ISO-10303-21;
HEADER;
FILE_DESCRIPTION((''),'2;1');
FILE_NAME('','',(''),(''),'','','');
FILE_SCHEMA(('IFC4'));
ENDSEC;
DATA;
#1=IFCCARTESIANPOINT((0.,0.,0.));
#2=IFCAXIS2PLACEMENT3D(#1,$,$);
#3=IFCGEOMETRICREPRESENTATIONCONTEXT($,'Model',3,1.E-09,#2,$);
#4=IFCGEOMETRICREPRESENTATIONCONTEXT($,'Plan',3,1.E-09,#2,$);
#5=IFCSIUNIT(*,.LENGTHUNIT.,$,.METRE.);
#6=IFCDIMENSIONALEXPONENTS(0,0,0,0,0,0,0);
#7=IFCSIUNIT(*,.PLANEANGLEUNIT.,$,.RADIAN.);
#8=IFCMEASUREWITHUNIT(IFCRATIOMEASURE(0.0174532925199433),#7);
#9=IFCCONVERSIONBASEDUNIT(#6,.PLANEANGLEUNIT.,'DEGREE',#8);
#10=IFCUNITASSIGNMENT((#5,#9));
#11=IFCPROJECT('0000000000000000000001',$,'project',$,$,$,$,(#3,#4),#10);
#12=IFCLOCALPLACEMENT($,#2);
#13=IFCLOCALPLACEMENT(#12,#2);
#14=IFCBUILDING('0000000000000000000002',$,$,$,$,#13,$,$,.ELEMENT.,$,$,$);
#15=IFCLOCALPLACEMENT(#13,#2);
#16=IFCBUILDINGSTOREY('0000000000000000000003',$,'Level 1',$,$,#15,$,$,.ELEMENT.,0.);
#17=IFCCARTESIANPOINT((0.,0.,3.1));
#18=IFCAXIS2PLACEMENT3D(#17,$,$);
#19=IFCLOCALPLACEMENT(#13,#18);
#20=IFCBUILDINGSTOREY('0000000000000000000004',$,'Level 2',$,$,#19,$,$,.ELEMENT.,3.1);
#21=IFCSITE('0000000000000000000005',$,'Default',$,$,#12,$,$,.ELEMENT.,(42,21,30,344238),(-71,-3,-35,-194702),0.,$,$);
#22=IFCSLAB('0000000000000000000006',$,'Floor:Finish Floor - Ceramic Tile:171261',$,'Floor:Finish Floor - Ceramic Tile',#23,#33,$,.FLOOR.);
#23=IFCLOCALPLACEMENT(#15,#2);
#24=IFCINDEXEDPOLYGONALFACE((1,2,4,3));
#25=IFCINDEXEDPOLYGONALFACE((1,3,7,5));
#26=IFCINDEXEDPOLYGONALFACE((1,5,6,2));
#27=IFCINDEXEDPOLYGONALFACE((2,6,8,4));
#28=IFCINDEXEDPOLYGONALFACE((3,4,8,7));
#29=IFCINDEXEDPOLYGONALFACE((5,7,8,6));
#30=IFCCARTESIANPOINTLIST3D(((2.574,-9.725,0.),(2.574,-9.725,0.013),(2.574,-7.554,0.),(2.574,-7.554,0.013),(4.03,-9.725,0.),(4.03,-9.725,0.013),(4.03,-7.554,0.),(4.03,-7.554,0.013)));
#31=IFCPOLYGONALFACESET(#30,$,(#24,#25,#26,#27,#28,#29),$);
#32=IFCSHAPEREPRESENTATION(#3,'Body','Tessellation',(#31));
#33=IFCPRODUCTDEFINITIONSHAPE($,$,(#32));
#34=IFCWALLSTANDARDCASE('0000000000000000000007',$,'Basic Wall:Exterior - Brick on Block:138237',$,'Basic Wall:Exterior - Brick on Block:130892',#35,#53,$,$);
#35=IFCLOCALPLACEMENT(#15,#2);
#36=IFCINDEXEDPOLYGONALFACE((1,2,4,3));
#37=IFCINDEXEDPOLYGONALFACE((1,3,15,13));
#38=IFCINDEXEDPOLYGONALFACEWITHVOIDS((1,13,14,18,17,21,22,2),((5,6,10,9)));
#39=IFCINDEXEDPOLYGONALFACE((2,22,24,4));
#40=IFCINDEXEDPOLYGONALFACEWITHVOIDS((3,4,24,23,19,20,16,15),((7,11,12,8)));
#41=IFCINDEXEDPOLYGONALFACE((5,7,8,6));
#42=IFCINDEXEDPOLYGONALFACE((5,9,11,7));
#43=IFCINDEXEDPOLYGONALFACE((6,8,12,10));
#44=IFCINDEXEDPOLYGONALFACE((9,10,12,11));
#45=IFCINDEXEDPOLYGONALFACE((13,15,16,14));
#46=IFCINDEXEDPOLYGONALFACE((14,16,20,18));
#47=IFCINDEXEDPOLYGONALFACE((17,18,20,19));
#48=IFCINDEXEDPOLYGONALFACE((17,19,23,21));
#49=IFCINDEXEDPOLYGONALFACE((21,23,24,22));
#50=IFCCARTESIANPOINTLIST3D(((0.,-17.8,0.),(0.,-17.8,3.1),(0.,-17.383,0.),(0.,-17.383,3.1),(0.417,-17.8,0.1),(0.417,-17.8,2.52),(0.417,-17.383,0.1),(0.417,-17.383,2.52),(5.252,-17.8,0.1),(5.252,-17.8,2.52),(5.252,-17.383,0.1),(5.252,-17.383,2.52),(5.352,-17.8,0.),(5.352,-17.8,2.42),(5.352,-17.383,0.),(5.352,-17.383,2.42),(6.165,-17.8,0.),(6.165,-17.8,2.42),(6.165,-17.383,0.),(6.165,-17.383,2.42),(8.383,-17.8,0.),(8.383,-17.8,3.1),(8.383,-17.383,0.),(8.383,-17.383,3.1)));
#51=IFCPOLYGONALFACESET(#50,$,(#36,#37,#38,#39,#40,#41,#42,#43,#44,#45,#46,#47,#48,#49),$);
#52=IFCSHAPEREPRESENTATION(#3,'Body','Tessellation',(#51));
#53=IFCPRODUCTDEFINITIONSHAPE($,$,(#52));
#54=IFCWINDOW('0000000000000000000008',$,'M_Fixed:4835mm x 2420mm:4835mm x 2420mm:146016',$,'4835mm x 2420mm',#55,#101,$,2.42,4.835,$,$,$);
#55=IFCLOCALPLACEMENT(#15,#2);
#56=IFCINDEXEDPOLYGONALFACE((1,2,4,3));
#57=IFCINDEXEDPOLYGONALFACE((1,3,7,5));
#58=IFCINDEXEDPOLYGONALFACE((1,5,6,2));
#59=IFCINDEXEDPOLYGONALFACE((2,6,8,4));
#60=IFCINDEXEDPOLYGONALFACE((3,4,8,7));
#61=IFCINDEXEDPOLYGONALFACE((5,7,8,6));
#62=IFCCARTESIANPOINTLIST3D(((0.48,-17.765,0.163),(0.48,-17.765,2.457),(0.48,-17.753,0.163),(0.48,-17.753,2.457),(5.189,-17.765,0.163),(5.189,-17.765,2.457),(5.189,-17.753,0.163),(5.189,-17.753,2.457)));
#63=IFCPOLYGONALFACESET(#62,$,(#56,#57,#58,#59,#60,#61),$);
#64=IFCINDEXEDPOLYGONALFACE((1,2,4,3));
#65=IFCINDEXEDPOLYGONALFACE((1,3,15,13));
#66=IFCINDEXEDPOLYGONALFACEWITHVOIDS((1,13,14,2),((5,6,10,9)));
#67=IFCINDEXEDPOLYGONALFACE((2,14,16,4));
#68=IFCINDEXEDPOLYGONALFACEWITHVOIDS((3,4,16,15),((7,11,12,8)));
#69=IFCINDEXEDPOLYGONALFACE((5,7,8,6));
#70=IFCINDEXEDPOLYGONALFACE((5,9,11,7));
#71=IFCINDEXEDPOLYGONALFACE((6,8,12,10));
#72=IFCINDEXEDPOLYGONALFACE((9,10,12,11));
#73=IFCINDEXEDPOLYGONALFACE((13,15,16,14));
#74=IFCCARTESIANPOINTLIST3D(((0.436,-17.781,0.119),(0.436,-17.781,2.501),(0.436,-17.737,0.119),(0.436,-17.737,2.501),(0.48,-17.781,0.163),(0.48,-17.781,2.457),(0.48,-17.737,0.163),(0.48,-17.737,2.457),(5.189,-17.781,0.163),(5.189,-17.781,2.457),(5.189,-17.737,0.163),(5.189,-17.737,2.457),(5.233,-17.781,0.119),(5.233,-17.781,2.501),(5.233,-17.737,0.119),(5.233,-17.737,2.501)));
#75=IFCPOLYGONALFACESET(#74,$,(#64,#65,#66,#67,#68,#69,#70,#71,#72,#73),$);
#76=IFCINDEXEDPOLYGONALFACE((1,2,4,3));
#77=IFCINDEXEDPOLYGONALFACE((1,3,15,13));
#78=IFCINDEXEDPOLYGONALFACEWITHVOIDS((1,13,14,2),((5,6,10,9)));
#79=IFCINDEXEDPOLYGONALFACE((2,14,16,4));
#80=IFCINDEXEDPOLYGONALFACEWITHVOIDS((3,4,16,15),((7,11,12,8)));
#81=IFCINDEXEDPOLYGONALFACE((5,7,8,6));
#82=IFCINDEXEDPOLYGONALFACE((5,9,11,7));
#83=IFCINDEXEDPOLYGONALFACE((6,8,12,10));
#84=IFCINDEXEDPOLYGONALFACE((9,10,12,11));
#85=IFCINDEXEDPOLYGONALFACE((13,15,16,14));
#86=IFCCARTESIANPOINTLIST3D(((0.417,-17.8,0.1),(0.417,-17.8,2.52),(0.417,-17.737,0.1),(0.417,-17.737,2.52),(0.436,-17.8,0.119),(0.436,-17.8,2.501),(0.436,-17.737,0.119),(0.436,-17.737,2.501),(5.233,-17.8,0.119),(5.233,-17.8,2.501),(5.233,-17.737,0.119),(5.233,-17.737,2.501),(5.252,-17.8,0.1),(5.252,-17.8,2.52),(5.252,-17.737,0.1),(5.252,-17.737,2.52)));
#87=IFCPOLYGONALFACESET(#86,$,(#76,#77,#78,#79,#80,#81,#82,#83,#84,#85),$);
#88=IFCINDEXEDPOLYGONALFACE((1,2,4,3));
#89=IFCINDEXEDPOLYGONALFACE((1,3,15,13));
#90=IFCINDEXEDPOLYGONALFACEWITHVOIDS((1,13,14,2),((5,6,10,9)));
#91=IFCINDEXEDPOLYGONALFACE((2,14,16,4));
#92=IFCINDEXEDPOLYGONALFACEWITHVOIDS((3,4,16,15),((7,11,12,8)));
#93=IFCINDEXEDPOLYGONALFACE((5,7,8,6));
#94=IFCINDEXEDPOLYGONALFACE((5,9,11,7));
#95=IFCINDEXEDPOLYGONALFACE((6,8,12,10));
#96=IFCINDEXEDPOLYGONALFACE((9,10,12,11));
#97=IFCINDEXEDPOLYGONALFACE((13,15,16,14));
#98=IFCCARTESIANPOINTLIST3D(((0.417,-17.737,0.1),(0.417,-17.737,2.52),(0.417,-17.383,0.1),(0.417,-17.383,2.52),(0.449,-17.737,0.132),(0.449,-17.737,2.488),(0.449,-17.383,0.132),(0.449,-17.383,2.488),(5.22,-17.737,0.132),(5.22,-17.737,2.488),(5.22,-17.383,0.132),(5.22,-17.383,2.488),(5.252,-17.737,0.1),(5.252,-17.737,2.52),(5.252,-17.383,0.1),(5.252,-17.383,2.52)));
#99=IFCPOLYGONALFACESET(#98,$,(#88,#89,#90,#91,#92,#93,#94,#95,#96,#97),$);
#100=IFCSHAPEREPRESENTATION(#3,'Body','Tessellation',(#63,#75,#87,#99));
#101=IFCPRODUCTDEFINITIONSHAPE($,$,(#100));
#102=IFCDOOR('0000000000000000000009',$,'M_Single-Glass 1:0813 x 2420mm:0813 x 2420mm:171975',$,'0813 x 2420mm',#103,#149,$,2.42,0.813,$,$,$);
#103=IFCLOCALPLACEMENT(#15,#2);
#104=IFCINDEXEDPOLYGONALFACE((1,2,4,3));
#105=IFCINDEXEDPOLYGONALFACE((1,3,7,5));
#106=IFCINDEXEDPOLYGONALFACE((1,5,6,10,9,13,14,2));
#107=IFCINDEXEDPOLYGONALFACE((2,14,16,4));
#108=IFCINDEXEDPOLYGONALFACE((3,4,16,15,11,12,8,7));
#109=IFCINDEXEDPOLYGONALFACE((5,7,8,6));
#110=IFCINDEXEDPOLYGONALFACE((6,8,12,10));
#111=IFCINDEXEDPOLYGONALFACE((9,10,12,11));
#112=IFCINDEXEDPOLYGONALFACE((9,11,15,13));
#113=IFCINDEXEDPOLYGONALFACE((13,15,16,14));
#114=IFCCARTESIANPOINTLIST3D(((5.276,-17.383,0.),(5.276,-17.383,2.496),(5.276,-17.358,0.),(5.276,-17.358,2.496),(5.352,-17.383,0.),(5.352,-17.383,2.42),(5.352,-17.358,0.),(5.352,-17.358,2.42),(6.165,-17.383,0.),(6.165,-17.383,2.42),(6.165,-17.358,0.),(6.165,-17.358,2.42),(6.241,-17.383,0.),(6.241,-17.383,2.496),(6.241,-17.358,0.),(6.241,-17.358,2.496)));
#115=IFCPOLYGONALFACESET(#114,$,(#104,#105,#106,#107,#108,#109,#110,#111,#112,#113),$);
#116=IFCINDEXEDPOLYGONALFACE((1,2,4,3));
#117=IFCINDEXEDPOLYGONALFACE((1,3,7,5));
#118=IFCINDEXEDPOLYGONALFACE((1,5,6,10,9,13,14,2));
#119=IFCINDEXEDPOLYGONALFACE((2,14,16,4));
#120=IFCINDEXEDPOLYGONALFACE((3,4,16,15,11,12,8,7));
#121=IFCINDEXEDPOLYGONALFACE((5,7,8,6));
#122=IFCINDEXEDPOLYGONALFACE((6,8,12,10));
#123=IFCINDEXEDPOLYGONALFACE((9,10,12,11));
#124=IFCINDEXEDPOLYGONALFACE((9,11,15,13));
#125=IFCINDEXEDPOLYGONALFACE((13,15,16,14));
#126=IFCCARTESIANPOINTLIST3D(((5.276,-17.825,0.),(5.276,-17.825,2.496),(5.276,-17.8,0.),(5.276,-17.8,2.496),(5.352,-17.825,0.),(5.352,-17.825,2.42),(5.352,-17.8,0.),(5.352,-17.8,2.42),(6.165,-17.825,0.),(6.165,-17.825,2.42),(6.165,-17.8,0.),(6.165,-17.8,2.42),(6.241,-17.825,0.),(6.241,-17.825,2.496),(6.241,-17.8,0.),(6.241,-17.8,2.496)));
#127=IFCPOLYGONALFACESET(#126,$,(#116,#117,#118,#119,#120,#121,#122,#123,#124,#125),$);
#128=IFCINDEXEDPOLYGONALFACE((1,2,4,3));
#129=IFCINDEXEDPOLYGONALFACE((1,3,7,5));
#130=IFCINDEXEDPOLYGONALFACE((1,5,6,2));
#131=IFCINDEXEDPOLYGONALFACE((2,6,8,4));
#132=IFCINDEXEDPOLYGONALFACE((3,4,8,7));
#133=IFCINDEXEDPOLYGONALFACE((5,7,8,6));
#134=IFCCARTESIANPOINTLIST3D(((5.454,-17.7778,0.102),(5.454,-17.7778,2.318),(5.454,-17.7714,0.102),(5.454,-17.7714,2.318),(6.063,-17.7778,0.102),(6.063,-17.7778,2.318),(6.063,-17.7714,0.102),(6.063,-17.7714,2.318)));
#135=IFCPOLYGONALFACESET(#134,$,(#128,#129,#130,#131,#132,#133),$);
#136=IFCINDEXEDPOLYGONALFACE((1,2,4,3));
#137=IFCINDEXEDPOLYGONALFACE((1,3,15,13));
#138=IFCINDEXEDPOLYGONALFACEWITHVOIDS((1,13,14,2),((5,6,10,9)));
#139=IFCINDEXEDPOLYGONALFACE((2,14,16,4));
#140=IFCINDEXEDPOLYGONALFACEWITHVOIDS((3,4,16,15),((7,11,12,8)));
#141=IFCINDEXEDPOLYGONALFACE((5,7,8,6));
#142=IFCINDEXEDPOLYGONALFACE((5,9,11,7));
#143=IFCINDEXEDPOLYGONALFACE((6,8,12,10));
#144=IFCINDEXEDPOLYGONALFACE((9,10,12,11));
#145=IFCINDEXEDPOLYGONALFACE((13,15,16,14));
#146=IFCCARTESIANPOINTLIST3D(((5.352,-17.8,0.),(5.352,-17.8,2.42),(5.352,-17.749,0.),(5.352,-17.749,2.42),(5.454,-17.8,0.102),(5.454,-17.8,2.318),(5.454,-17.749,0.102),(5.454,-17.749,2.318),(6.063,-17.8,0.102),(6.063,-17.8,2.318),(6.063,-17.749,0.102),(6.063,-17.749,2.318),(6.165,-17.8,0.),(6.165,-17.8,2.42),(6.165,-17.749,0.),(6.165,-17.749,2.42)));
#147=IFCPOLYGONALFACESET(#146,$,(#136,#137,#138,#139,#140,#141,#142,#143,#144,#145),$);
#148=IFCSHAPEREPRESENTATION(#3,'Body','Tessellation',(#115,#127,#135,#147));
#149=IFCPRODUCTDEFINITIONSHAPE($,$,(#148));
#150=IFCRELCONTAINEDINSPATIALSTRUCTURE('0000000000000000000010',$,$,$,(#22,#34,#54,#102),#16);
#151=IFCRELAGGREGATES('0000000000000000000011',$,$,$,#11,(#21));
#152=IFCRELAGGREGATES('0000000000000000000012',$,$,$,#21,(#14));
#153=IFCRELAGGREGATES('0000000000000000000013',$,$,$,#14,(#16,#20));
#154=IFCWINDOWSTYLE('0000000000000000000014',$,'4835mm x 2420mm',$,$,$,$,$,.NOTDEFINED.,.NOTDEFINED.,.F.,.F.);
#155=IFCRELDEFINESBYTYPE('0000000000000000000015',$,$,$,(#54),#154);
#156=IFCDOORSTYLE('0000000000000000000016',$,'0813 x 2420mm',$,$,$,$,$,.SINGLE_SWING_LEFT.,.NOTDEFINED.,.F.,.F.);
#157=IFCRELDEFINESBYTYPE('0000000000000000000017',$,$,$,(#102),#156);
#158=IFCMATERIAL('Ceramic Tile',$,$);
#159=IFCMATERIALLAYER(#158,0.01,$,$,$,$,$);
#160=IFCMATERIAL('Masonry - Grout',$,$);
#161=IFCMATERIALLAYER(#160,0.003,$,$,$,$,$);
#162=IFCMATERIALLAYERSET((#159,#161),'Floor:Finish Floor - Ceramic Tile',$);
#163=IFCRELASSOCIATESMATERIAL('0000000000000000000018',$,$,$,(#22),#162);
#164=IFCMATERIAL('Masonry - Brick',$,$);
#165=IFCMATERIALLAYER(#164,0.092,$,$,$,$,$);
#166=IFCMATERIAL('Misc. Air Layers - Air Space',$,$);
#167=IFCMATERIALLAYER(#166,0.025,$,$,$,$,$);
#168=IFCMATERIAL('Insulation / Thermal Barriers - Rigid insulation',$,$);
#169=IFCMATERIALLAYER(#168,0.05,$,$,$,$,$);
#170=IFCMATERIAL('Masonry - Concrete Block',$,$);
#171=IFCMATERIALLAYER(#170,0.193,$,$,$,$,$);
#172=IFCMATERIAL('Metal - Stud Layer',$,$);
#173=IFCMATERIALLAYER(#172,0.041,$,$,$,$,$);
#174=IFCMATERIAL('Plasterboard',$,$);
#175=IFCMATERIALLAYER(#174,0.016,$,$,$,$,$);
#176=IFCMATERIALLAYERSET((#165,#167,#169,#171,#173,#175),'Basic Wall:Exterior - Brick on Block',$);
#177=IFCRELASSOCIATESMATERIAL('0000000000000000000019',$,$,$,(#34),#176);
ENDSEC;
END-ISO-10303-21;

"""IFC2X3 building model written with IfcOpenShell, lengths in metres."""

from ifc_helpers import new_model, entity, si_unit, converted_unit, frame, frame_2d, origin, origin_2d_with_axis, place, context, project, spatial, polyline, rectangle, outline, extrude, source, transform, mapped, material, layer, layer_set, layer_usage, type_object, type_shapes, element, fill, save


model = new_model("IFC2X3")

# Units and contexts
model_context = context("Model", 3, precision=1e-09, world=origin())
plan_context = context("Plan", 3, precision=1e-09, world=origin())
ifc_project = project(units=[si_unit("LENGTHUNIT", "METRE"), converted_unit("PLANEANGLEUNIT", "DEGREE", entity("IfcRatioMeasure", 0.0174532925199433), si_unit("PLANEANGLEUNIT", "RADIAN"), dimensions=[0, 0, 0, 0, 0, 0, 0])], contexts=[model_context, plan_context])

# Site, building, storey
site_placement = place(None, origin())
site = spatial("IfcSite", under=ifc_project, at=site_placement, Name="Default", CompositionType="ELEMENT", RefLatitude=(42, 21, 30, 344238), RefLongitude=(-71, -3, -35, -194702), RefElevation=0.0)
building_placement = place(site_placement, origin())
building = spatial("IfcBuilding", under=site, at=building_placement, CompositionType="ELEMENT")
storey_1_placement = place(building_placement, origin())
storey_1 = spatial("IfcBuildingStorey", under=building, at=storey_1_placement, Name="Level 1", CompositionType="ELEMENT", Elevation=0.0)

# Slab
ifc_material_1 = material(Name="Ceramic Tile")
ifc_layer_1 = layer(ifc_material_1, 0.01)
ifc_material_2 = material(Name="Masonry - Grout")
ifc_layer_2 = layer(ifc_material_2, 0.003)
ifc_layer_set_1 = layer_set([ifc_layer_1, ifc_layer_2], Name="Floor:Finish Floor - Ceramic Tile")
ifc_layer_usage_1 = layer_usage(ifc_layer_set_1, "AXIS3", "POSITIVE", 0.0)
slab_1_placement = place(storey_1_placement, frame((2.574, -9.725, 0.0)))
element("IfcSlab", 1, at=slab_1_placement, inside=storey_1, material=ifc_layer_usage_1, Name="Floor:Finish Floor - Ceramic Tile:171261", ObjectType="Floor:Finish Floor - Ceramic Tile", PredefinedType="FLOOR", context=model_context, shape_type="SweptSolid", body=[
    extrude(rectangle(XDim=2.171, YDim=1.456, at=frame_2d((0.0, 0.0), x_axis=(0.0, -1.0))), frame((0.728, 1.0855, 0.013), z_axis=(0.0, 0.0, -1.0), x_axis=(-1.0, 0.0, 0.0)), (0.0, 0.0, 1.0), 0.013),
])

# Wall, openings, window, door
ifc_material_3 = material(Name="Masonry - Brick")
ifc_layer_3 = layer(ifc_material_3, 0.092)
ifc_material_4 = material(Name="Misc. Air Layers - Air Space")
ifc_layer_4 = layer(ifc_material_4, 0.025)
ifc_material_5 = material(Name="Insulation / Thermal Barriers - Rigid insulation")
ifc_layer_5 = layer(ifc_material_5, 0.05)
ifc_material_6 = material(Name="Masonry - Concrete Block")
ifc_layer_6 = layer(ifc_material_6, 0.193)
ifc_material_7 = material(Name="Metal - Stud Layer")
ifc_layer_7 = layer(ifc_material_7, 0.041)
ifc_material_8 = material(Name="Plasterboard")
ifc_layer_8 = layer(ifc_material_8, 0.016)
ifc_layer_set_2 = layer_set([ifc_layer_3, ifc_layer_4, ifc_layer_5, ifc_layer_6, ifc_layer_7, ifc_layer_8], Name="Basic Wall:Exterior - Brick on Block")
ifc_layer_usage_2 = layer_usage(ifc_layer_set_2, "AXIS2", "NEGATIVE", 0.2085)
wall_1_placement = place(storey_1_placement, frame((8.383, -17.5915, 0.0), z_axis=(0.0, 0.0, 1.0), x_axis=(-1.0, 0.0, 0.0)))
wall_1 = element("IfcWallStandardCase", 2, at=wall_1_placement, inside=storey_1, material=ifc_layer_usage_2, Name="Basic Wall:Exterior - Brick on Block:138237", ObjectType="Basic Wall:Exterior - Brick on Block:130892", context=model_context, shape_type="SweptSolid", body=[
    extrude(rectangle(XDim=8.383, YDim=0.417, at=frame_2d((4.1915, 0.0), x_axis=(-1.0, 0.0))), origin(), (0.0, 0.0, 1.0), 3.1),
])
opening_1_placement = place(wall_1_placement, frame((3.131, -0.2085, 0.1)))
opening_1 = element("IfcOpeningElement", 3, at=opening_1_placement, cuts=wall_1, ObjectType="Opening", context=model_context, shape_type="SweptSolid", body=[
    extrude(rectangle(XDim=2.42, YDim=4.835, at=frame_2d((1.21, 2.4175), x_axis=(1.0, 0.0))), frame((0.0, 0.0, 0.0), z_axis=(0.0, 1.0, 0.0), x_axis=(0.0, 0.0, 1.0)), (0.0, 0.0, 1.0), 0.417),
])
opening_2_placement = place(wall_1_placement, frame((2.218, -0.2085, 0.0)))
opening_2 = element("IfcOpeningElement", 4, at=opening_2_placement, cuts=wall_1, ObjectType="Opening", context=model_context, shape_type="SweptSolid", body=[
    extrude(rectangle(XDim=0.813, YDim=2.42, at=frame_2d((1.21, 0.4065), x_axis=(0.0, -1.0))), frame((0.0, 0.0, 0.0), z_axis=(0.0, 1.0, 0.0), x_axis=(0.0, 0.0, 1.0)), (0.0, 0.0, 1.0), 0.417),
])
window_style_1 = type_object("IfcWindowStyle", Name="4835mm x 2420mm", ConstructionType="NOTDEFINED", OperationType="NOTDEFINED", ParameterTakesPrecedence=False, Sizeable=False)
shared_shape_1 = source(origin(), model_context, "Body", "SweptSolid", [
    extrude(rectangle(XDim=0.012, YDim=4.709, at=origin_2d_with_axis()), frame((2.4175, 0.376, 0.063), z_axis=(0.0, 0.0, 1.0), x_axis=(0.0, -1.0, 0.0)), (0.0, 0.0, 1.0), 2.294),
    extrude(outline(polyline([(-2.3985, -1.191), (2.3985, -1.191), (2.3985, 1.191), (-2.3985, 1.191), (-2.3985, -1.191)]), holes=[polyline([(-2.3545, -1.147), (-2.3545, 1.147), (2.3545, 1.147), (2.3545, -1.147), (-2.3545, -1.147)])]), frame((2.4175, 0.354, 1.21), z_axis=(0.0, 1.0, 0.0), x_axis=(1.0, 0.0, 0.0)), (0.0, 0.0, 1.0), 0.044),
    extrude(outline(polyline([(-2.4175, -1.21), (2.4175, -1.21), (2.4175, 1.21), (-2.4175, 1.21), (-2.4175, -1.21)]), holes=[polyline([(-2.3985, -1.191), (-2.3985, 1.191), (2.3985, 1.191), (2.3985, -1.191), (-2.3985, -1.191)])]), frame((2.4175, 0.354, 1.21), z_axis=(0.0, 1.0, 0.0), x_axis=(1.0, 0.0, 0.0)), (0.0, 0.0, 1.0), 0.063),
    extrude(outline(polyline([(-2.4175, -1.21), (2.4175, -1.21), (2.4175, 1.21), (-2.4175, 1.21), (-2.4175, -1.21)]), holes=[polyline([(-2.3855, -1.178), (-2.3855, 1.178), (2.3855, 1.178), (2.3855, -1.178), (-2.3855, -1.178)])]), frame((2.4175, 0.0, 1.21), z_axis=(0.0, 1.0, 0.0), x_axis=(1.0, 0.0, 0.0)), (0.0, 0.0, 1.0), 0.354),
])
type_shapes(window_style_1, [shared_shape_1])
window_1_placement = place(opening_1_placement, origin())
window_1 = element("IfcWindow", 5, at=window_1_placement, inside=storey_1, type_object=window_style_1, Name="M_Fixed:4835mm x 2420mm:4835mm x 2420mm:146016", ObjectType="4835mm x 2420mm", OverallHeight=2.42, OverallWidth=4.835, context=model_context, shape_type="MappedRepresentation", body=[
    mapped(shared_shape_1, transform((0.0, 0.0, 0.0), scale=1.0)),
])
fill(opening_1, window_1)
door_style_1 = type_object("IfcDoorStyle", Name="0813 x 2420mm", ConstructionType="NOTDEFINED", OperationType="SINGLE_SWING_LEFT", ParameterTakesPrecedence=False, Sizeable=False)
shared_shape_2 = source(origin(), model_context, "Body", "SweptSolid", [
    extrude(outline(polyline([(-0.4065, -1.191), (-0.4065, 1.229), (-0.4825, 1.229), (-0.4825, -1.267), (0.4825, -1.267), (0.4825, 1.229), (0.4065, 1.229), (0.4065, -1.191), (-0.4065, -1.191)])), frame((0.4065, 0.0, 1.229), z_axis=(0.0, 1.0, 0.0), x_axis=(1.0, 0.0, 0.0)), (0.0, 0.0, -1.0), 0.025),
    extrude(outline(polyline([(-0.4065, -1.191), (-0.4065, 1.229), (-0.4825, 1.229), (-0.4825, -1.267), (0.4825, -1.267), (0.4825, 1.229), (0.4065, 1.229), (0.4065, -1.191), (-0.4065, -1.191)])), frame((0.4065, 0.442, 1.229), z_axis=(0.0, 1.0, 0.0), x_axis=(1.0, 0.0, 0.0)), (0.0, 0.0, -1.0), 0.025),
    extrude(rectangle(XDim=0.609, YDim=0.0064, at=origin_2d_with_axis()), frame((0.4065, 0.3916, 0.102)), (0.0, 0.0, 1.0), 2.216),
    extrude(outline(polyline([(-1.21, -0.4065), (1.21, -0.4065), (1.21, 0.4065), (-1.21, 0.4065), (-1.21, -0.4065)]), holes=[polyline([(-1.108, 0.3045), (1.108, 0.3045), (1.108, -0.3045), (-1.108, -0.3045), (-1.108, 0.3045)])]), frame((0.4065, 0.417, 1.21), z_axis=(0.0, -1.0, 0.0), x_axis=(0.0, 0.0, -1.0)), (0.0, 0.0, 1.0), 0.051),
])
type_shapes(door_style_1, [shared_shape_2])
door_1_placement = place(opening_2_placement, origin())
door_1 = element("IfcDoor", 6, at=door_1_placement, inside=storey_1, type_object=door_style_1, Name="M_Single-Glass 1:0813 x 2420mm:0813 x 2420mm:171975", ObjectType="0813 x 2420mm", OverallHeight=2.42, OverallWidth=0.813, context=model_context, shape_type="MappedRepresentation", body=[
    mapped(shared_shape_2, transform((0.0, 0.0, 0.0), scale=1.0)),
])
fill(opening_2, door_1)

# Shared definitions
storey_2_placement = place(building_placement, frame((0.0, 0.0, 3.1)))
storey_2 = spatial("IfcBuildingStorey", under=building, at=storey_2_placement, Name="Level 2", CompositionType="ELEMENT", Elevation=3.1)

save(model, "model.ifc")
